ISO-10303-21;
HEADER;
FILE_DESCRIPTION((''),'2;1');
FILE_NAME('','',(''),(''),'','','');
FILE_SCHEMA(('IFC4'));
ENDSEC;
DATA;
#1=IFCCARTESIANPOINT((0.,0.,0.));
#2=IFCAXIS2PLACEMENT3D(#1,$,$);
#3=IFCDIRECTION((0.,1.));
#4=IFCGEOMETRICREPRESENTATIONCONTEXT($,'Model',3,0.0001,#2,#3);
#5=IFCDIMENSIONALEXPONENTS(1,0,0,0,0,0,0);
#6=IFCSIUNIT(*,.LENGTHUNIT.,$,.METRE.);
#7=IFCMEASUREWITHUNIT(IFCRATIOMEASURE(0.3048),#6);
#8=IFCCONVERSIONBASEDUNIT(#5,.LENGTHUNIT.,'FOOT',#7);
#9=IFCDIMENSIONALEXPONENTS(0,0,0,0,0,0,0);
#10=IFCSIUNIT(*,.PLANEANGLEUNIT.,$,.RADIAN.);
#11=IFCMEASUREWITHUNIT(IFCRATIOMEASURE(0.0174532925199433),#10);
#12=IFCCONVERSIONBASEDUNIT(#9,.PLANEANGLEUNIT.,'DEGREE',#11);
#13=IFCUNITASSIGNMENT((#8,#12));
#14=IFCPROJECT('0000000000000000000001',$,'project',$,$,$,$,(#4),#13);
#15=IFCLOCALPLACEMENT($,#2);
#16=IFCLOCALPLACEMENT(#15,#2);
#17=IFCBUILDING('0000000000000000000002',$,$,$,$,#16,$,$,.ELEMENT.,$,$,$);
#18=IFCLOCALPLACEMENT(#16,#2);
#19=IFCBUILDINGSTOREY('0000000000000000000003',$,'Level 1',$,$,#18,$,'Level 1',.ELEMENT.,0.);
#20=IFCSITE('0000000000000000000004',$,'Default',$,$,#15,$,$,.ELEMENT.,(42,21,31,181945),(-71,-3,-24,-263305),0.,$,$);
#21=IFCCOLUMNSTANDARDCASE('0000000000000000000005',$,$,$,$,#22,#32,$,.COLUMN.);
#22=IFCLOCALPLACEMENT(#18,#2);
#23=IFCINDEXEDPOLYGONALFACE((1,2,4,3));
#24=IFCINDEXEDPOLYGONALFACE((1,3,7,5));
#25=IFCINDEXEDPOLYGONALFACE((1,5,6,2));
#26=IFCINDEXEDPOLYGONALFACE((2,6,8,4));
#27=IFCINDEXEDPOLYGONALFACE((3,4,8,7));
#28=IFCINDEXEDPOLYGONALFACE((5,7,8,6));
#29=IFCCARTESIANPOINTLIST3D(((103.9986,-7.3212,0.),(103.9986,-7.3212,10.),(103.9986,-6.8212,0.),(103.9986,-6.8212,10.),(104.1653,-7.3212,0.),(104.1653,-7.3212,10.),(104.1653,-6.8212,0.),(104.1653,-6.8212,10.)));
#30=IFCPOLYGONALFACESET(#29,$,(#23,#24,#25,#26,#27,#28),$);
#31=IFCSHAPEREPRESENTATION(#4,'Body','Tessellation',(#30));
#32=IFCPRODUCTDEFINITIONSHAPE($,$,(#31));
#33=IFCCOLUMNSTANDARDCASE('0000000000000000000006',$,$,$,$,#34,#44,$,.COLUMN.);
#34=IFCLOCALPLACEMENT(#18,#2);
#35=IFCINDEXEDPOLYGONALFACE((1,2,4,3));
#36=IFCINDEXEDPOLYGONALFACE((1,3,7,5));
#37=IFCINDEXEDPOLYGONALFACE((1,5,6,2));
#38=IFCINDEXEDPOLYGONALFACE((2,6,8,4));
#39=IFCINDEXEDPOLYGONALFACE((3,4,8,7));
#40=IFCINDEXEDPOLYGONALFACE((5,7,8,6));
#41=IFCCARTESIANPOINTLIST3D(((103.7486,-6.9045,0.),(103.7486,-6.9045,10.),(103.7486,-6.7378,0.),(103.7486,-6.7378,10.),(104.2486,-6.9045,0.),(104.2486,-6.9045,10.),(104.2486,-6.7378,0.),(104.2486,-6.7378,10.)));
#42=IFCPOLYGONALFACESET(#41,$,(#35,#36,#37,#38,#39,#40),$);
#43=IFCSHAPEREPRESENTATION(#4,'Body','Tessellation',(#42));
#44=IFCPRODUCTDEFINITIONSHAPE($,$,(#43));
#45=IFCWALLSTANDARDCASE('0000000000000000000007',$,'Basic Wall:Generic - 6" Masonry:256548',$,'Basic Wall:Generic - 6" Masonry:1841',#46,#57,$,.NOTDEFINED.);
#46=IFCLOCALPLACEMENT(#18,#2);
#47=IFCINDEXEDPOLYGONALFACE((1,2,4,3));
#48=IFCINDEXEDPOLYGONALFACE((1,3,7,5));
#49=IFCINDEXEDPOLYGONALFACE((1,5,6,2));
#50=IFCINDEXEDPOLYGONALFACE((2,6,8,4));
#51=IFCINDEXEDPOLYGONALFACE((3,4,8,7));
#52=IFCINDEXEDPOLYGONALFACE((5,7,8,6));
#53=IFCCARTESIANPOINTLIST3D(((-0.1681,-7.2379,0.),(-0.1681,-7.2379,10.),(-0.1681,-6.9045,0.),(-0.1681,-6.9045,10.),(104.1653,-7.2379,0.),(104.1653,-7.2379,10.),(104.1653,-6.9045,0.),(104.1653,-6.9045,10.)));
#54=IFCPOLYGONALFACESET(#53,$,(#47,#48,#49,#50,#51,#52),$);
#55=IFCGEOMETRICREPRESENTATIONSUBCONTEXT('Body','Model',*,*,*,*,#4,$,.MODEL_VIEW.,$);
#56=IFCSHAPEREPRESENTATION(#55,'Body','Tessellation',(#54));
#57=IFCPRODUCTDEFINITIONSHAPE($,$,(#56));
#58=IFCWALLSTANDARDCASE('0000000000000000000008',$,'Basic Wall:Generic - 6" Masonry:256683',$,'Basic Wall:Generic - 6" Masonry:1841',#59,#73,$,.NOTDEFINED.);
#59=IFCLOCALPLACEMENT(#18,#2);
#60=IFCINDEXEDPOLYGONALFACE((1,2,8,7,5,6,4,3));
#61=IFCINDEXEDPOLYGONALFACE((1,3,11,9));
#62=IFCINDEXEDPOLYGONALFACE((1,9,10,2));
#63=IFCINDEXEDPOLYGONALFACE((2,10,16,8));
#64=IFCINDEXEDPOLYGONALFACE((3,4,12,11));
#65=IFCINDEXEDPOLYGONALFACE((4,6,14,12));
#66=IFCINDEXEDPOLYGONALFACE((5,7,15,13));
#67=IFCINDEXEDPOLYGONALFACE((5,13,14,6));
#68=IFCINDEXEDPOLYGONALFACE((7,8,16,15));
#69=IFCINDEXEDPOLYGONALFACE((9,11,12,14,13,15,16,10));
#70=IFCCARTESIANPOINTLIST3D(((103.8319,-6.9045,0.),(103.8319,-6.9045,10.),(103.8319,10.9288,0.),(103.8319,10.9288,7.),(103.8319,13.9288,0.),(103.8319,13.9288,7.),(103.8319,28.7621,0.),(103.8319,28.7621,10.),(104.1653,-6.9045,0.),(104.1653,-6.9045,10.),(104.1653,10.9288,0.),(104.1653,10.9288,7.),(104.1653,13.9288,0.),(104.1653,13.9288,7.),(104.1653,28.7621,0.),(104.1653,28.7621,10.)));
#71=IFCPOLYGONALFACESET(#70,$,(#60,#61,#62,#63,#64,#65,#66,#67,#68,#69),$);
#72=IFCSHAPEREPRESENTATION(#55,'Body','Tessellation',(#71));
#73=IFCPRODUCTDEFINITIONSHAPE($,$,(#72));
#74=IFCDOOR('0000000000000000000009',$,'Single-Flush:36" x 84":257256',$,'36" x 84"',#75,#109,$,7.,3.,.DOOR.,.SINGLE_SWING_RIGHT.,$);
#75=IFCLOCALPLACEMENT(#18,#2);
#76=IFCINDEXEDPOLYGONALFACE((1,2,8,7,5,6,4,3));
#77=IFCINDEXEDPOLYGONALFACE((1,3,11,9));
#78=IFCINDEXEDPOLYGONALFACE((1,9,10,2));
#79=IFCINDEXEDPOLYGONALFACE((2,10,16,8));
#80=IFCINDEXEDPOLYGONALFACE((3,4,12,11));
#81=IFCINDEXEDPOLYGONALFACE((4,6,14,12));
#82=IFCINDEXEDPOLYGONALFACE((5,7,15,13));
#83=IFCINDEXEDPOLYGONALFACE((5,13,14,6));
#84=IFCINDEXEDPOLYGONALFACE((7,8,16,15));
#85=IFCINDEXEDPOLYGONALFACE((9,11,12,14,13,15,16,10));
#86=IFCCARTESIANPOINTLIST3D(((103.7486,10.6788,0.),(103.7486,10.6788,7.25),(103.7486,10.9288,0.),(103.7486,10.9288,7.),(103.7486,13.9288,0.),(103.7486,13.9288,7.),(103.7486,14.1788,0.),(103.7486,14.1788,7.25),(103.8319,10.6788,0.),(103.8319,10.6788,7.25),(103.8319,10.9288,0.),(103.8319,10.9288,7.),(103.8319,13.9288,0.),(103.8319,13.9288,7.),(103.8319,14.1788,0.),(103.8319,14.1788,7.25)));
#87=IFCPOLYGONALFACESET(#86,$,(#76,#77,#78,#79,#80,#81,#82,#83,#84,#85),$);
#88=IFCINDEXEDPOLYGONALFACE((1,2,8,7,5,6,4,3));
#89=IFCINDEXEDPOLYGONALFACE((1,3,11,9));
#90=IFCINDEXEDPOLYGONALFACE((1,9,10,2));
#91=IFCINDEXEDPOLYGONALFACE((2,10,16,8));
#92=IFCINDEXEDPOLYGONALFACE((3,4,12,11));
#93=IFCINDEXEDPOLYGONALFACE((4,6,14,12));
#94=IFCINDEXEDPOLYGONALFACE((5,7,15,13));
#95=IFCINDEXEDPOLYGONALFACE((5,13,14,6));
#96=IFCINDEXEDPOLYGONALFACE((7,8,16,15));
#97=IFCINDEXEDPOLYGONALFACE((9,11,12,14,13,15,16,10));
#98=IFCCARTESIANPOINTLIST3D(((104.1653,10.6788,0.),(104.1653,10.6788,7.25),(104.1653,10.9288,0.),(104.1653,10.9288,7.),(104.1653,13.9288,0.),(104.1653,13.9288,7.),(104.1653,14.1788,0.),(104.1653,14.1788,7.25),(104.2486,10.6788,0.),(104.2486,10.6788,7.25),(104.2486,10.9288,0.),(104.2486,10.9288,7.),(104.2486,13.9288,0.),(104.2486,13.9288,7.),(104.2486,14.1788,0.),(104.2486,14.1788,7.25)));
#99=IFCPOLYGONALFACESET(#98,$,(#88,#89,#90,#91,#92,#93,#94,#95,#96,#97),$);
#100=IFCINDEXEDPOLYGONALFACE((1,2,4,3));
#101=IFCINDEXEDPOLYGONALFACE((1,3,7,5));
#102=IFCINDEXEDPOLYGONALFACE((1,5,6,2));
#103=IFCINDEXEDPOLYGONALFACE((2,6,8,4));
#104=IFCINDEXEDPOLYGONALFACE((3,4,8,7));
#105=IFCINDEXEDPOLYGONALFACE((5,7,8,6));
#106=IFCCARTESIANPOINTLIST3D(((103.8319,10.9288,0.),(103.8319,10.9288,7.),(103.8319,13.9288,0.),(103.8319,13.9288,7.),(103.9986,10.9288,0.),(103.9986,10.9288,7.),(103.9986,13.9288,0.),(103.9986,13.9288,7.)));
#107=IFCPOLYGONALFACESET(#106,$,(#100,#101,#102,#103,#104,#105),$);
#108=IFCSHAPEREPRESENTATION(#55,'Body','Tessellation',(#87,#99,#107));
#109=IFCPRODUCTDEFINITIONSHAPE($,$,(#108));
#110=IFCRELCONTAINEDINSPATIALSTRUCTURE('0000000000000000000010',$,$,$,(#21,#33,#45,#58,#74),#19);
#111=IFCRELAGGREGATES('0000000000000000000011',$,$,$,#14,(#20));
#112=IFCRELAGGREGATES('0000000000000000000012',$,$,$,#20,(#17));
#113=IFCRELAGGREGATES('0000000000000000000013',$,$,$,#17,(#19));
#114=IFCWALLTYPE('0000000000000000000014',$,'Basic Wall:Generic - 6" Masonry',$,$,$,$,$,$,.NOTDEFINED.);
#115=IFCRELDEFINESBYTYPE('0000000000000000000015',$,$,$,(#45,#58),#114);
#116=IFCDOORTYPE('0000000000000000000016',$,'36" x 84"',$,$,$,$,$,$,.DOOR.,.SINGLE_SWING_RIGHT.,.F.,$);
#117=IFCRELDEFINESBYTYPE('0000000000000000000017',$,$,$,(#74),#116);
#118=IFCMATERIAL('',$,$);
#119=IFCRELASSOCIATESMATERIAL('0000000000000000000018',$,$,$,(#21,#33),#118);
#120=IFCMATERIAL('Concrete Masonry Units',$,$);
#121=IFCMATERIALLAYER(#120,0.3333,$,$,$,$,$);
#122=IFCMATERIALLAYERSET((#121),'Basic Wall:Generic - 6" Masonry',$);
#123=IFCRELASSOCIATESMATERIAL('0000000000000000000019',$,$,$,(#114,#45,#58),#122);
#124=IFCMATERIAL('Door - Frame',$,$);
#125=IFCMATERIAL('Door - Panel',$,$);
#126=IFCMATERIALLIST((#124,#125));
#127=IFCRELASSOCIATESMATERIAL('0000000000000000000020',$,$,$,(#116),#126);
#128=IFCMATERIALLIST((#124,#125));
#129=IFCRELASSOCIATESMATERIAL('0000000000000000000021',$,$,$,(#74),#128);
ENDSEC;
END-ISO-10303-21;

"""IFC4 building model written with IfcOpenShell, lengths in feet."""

from ifc_helpers import new_model, entity, si_unit, converted_unit, direction, frame, frame_2d, origin, place, context, subcontext, project, spatial, polyline, rectangle, outline, extrude, source, transform, mapped, material, material_list, layer, layer_set, layer_usage, type_object, type_shapes, element, fill, save


model = new_model("IFC4")

# Units and contexts
model_context = context("Model", 3, precision=0.0001, world=origin(), true_north=direction((0.0, 1.0)))
body_context = subcontext(model_context, "Body", "Model", "MODEL_VIEW")
ifc_project = project(units=[converted_unit("LENGTHUNIT", "FOOT", entity("IfcRatioMeasure", 0.3048), si_unit("LENGTHUNIT", "METRE"), dimensions=[1, 0, 0, 0, 0, 0, 0]), converted_unit("PLANEANGLEUNIT", "DEGREE", entity("IfcRatioMeasure", 0.0174532925199433), si_unit("PLANEANGLEUNIT", "RADIAN"), dimensions=[0, 0, 0, 0, 0, 0, 0])], contexts=[model_context])

# Site, building, storey
site_placement = place(None, origin())
site = spatial("IfcSite", under=ifc_project, at=site_placement, Name="Default", CompositionType="ELEMENT", RefLatitude=(42, 21, 31, 181945), RefLongitude=(-71, -3, -24, -263305), RefElevation=0.0)
building_placement = place(site_placement, origin())
building = spatial("IfcBuilding", under=site, at=building_placement, CompositionType="ELEMENT")
storey_placement = place(building_placement, origin())
storey = spatial("IfcBuildingStorey", under=building, at=storey_placement, Name="Level 1", LongName="Level 1", CompositionType="ELEMENT", Elevation=0.0)

# Columns
ifc_material_1 = material(Name="")
wall_1_placement = place(storey_placement, frame((104.1653, -7.0712, 0.0), z_axis=(0.0, 0.0, 1.0), x_axis=(-1.0, 0.0, 0.0)))
for number, where, z_axis, x_axis in (
    (1, (0.0833, 0.0, 0.0), (0.0, 0.0, 1.0), (1.0, 0.0, 0.0)),
):
    element("IfcColumnStandardCase", number, at=place(wall_1_placement, frame(where, z_axis=z_axis, x_axis=x_axis)), inside=storey, material=ifc_material_1, PredefinedType="COLUMN", context=model_context, shape_type="SweptSolid", body=[
        extrude(rectangle(XDim=0.1667, YDim=0.5), origin(), (0.0, 0.0, 1.0), 10.0),
    ])
wall_2_placement = place(storey_placement, frame((103.9986, -6.9045, 0.0), z_axis=(0.0, 0.0, 1.0), x_axis=(0.0, 1.0, 0.0)))
for number, where, z_axis, x_axis in (
    (2, (0.0833, 0.0, 0.0), (0.0, 0.0, 1.0), (1.0, 0.0, 0.0)),
):
    element("IfcColumnStandardCase", number, at=place(wall_2_placement, frame(where, z_axis=z_axis, x_axis=x_axis)), inside=storey, material=ifc_material_1, PredefinedType="COLUMN", context=model_context, shape_type="SweptSolid", body=[
        extrude(rectangle(XDim=0.1667, YDim=0.5), origin(), (0.0, 0.0, 1.0), 10.0),
    ])

# Wall
ifc_material_2 = material(Name="Concrete Masonry Units")
ifc_layer = layer(ifc_material_2, 0.3333)
ifc_layer_set = layer_set([ifc_layer], Name="Basic Wall:Generic - 6\" Masonry")
ifc_layer_usage_1 = layer_usage(ifc_layer_set, "AXIS2", "NEGATIVE", 0.1667)
wall_type = type_object("IfcWallType", Name="Basic Wall:Generic - 6\" Masonry", PredefinedType="NOTDEFINED", material=ifc_layer_set)
element("IfcWallStandardCase", 3, at=wall_1_placement, inside=storey, type_object=wall_type, material=ifc_layer_usage_1, Name="Basic Wall:Generic - 6\" Masonry:256548", ObjectType="Basic Wall:Generic - 6\" Masonry:1841", PredefinedType="NOTDEFINED", context=body_context, shape_type="SweptSolid", body=[
    extrude(rectangle(XDim=104.3333, YDim=0.3333, at=frame_2d((52.1667, 0.0), x_axis=(-1.0, 0.0))), origin(), (0.0, 0.0, 1.0), 10.0),
])

# Wall, opening, door
ifc_layer_usage_2 = layer_usage(ifc_layer_set, "AXIS2", "NEGATIVE", 0.1667)
wall_2 = element("IfcWallStandardCase", 4, at=wall_2_placement, inside=storey, type_object=wall_type, material=ifc_layer_usage_2, Name="Basic Wall:Generic - 6\" Masonry:256683", ObjectType="Basic Wall:Generic - 6\" Masonry:1841", PredefinedType="NOTDEFINED", context=body_context, shape_type="SweptSolid", body=[
    extrude(rectangle(XDim=35.6667, YDim=0.3333, at=frame_2d((17.8333, 0.0), x_axis=(-1.0, 0.0))), origin(), (0.0, 0.0, 1.0), 10.0),
])
opening_placement = place(wall_2_placement, frame((17.8333, -0.1667, 0.0)))
opening = element("IfcOpeningElement", 5, at=opening_placement, cuts=wall_2, ObjectType="Opening", PredefinedType="OPENING", context=body_context, shape_type="SweptSolid", body=[
    extrude(rectangle(XDim=3.0, YDim=7.0, at=frame_2d((3.5, 1.5), x_axis=(0.0, 1.0))), frame((0.0, 0.0, 0.0), z_axis=(0.0, 1.0, 0.0), x_axis=(0.0, 0.0, 1.0)), (0.0, 0.0, 1.0), 0.3333),
])
ifc_material_3 = material(Name="Door - Frame")
ifc_material_4 = material(Name="Door - Panel")
ifc_material_list_1 = material_list([ifc_material_3, ifc_material_4])
ifc_material_list_2 = material_list([ifc_material_3, ifc_material_4])
door_type = type_object("IfcDoorType", Name="36\" x 84\"", OperationType="SINGLE_SWING_RIGHT", ParameterTakesPrecedence=False, PredefinedType="DOOR", material=ifc_material_list_2)
shared_shape = source(origin(), body_context, "Body", "SweptSolid", [
    extrude(outline(polyline([(-1.75, -3.6875), (1.75, -3.6875), (1.75, 3.5625), (1.5, 3.5625), (1.5, -3.4375), (-1.5, -3.4375), (-1.5, 3.5625), (-1.75, 3.5625), (-1.75, -3.6875)])), frame((1.5, 0.3333, 3.5625), z_axis=(0.0, 1.0, 0.0), x_axis=(1.0, 0.0, 0.0)), (0.0, 0.0, 1.0), 0.0833),
    extrude(outline(polyline([(-3.6875, -1.75), (3.5625, -1.75), (3.5625, -1.5), (-3.4375, -1.5), (-3.4375, 1.5), (3.5625, 1.5), (3.5625, 1.75), (-3.6875, 1.75), (-3.6875, -1.75)])), frame((1.5, -0.0833, 3.5625), z_axis=(0.0, 1.0, 0.0), x_axis=(0.0, 0.0, -1.0)), (0.0, 0.0, 1.0), 0.0833),
    extrude(rectangle(XDim=0.1667, YDim=3.0, at=frame_2d((0.0, 0.0), x_axis=(1.0, 0.0))), frame((1.5, 0.25, 0.0), z_axis=(0.0, 0.0, 1.0), x_axis=(0.0, 1.0, 0.0)), (0.0, 0.0, 1.0), 7.0),
])
type_shapes(door_type, [shared_shape])
door_placement = place(opening_placement, origin())
door = element("IfcDoor", 6, at=door_placement, inside=storey, type_object=door_type, material=ifc_material_list_1, Name="Single-Flush:36\" x 84\":257256", ObjectType="36\" x 84\"", OperationType="SINGLE_SWING_RIGHT", OverallHeight=7.0, OverallWidth=3.0, PredefinedType="DOOR", context=body_context, shape_type="MappedRepresentation", body=[
    mapped(shared_shape, transform((0.0, 0.0, 0.0), scale=1.0)),
])
fill(opening, door)

save(model, "model.ifc")
